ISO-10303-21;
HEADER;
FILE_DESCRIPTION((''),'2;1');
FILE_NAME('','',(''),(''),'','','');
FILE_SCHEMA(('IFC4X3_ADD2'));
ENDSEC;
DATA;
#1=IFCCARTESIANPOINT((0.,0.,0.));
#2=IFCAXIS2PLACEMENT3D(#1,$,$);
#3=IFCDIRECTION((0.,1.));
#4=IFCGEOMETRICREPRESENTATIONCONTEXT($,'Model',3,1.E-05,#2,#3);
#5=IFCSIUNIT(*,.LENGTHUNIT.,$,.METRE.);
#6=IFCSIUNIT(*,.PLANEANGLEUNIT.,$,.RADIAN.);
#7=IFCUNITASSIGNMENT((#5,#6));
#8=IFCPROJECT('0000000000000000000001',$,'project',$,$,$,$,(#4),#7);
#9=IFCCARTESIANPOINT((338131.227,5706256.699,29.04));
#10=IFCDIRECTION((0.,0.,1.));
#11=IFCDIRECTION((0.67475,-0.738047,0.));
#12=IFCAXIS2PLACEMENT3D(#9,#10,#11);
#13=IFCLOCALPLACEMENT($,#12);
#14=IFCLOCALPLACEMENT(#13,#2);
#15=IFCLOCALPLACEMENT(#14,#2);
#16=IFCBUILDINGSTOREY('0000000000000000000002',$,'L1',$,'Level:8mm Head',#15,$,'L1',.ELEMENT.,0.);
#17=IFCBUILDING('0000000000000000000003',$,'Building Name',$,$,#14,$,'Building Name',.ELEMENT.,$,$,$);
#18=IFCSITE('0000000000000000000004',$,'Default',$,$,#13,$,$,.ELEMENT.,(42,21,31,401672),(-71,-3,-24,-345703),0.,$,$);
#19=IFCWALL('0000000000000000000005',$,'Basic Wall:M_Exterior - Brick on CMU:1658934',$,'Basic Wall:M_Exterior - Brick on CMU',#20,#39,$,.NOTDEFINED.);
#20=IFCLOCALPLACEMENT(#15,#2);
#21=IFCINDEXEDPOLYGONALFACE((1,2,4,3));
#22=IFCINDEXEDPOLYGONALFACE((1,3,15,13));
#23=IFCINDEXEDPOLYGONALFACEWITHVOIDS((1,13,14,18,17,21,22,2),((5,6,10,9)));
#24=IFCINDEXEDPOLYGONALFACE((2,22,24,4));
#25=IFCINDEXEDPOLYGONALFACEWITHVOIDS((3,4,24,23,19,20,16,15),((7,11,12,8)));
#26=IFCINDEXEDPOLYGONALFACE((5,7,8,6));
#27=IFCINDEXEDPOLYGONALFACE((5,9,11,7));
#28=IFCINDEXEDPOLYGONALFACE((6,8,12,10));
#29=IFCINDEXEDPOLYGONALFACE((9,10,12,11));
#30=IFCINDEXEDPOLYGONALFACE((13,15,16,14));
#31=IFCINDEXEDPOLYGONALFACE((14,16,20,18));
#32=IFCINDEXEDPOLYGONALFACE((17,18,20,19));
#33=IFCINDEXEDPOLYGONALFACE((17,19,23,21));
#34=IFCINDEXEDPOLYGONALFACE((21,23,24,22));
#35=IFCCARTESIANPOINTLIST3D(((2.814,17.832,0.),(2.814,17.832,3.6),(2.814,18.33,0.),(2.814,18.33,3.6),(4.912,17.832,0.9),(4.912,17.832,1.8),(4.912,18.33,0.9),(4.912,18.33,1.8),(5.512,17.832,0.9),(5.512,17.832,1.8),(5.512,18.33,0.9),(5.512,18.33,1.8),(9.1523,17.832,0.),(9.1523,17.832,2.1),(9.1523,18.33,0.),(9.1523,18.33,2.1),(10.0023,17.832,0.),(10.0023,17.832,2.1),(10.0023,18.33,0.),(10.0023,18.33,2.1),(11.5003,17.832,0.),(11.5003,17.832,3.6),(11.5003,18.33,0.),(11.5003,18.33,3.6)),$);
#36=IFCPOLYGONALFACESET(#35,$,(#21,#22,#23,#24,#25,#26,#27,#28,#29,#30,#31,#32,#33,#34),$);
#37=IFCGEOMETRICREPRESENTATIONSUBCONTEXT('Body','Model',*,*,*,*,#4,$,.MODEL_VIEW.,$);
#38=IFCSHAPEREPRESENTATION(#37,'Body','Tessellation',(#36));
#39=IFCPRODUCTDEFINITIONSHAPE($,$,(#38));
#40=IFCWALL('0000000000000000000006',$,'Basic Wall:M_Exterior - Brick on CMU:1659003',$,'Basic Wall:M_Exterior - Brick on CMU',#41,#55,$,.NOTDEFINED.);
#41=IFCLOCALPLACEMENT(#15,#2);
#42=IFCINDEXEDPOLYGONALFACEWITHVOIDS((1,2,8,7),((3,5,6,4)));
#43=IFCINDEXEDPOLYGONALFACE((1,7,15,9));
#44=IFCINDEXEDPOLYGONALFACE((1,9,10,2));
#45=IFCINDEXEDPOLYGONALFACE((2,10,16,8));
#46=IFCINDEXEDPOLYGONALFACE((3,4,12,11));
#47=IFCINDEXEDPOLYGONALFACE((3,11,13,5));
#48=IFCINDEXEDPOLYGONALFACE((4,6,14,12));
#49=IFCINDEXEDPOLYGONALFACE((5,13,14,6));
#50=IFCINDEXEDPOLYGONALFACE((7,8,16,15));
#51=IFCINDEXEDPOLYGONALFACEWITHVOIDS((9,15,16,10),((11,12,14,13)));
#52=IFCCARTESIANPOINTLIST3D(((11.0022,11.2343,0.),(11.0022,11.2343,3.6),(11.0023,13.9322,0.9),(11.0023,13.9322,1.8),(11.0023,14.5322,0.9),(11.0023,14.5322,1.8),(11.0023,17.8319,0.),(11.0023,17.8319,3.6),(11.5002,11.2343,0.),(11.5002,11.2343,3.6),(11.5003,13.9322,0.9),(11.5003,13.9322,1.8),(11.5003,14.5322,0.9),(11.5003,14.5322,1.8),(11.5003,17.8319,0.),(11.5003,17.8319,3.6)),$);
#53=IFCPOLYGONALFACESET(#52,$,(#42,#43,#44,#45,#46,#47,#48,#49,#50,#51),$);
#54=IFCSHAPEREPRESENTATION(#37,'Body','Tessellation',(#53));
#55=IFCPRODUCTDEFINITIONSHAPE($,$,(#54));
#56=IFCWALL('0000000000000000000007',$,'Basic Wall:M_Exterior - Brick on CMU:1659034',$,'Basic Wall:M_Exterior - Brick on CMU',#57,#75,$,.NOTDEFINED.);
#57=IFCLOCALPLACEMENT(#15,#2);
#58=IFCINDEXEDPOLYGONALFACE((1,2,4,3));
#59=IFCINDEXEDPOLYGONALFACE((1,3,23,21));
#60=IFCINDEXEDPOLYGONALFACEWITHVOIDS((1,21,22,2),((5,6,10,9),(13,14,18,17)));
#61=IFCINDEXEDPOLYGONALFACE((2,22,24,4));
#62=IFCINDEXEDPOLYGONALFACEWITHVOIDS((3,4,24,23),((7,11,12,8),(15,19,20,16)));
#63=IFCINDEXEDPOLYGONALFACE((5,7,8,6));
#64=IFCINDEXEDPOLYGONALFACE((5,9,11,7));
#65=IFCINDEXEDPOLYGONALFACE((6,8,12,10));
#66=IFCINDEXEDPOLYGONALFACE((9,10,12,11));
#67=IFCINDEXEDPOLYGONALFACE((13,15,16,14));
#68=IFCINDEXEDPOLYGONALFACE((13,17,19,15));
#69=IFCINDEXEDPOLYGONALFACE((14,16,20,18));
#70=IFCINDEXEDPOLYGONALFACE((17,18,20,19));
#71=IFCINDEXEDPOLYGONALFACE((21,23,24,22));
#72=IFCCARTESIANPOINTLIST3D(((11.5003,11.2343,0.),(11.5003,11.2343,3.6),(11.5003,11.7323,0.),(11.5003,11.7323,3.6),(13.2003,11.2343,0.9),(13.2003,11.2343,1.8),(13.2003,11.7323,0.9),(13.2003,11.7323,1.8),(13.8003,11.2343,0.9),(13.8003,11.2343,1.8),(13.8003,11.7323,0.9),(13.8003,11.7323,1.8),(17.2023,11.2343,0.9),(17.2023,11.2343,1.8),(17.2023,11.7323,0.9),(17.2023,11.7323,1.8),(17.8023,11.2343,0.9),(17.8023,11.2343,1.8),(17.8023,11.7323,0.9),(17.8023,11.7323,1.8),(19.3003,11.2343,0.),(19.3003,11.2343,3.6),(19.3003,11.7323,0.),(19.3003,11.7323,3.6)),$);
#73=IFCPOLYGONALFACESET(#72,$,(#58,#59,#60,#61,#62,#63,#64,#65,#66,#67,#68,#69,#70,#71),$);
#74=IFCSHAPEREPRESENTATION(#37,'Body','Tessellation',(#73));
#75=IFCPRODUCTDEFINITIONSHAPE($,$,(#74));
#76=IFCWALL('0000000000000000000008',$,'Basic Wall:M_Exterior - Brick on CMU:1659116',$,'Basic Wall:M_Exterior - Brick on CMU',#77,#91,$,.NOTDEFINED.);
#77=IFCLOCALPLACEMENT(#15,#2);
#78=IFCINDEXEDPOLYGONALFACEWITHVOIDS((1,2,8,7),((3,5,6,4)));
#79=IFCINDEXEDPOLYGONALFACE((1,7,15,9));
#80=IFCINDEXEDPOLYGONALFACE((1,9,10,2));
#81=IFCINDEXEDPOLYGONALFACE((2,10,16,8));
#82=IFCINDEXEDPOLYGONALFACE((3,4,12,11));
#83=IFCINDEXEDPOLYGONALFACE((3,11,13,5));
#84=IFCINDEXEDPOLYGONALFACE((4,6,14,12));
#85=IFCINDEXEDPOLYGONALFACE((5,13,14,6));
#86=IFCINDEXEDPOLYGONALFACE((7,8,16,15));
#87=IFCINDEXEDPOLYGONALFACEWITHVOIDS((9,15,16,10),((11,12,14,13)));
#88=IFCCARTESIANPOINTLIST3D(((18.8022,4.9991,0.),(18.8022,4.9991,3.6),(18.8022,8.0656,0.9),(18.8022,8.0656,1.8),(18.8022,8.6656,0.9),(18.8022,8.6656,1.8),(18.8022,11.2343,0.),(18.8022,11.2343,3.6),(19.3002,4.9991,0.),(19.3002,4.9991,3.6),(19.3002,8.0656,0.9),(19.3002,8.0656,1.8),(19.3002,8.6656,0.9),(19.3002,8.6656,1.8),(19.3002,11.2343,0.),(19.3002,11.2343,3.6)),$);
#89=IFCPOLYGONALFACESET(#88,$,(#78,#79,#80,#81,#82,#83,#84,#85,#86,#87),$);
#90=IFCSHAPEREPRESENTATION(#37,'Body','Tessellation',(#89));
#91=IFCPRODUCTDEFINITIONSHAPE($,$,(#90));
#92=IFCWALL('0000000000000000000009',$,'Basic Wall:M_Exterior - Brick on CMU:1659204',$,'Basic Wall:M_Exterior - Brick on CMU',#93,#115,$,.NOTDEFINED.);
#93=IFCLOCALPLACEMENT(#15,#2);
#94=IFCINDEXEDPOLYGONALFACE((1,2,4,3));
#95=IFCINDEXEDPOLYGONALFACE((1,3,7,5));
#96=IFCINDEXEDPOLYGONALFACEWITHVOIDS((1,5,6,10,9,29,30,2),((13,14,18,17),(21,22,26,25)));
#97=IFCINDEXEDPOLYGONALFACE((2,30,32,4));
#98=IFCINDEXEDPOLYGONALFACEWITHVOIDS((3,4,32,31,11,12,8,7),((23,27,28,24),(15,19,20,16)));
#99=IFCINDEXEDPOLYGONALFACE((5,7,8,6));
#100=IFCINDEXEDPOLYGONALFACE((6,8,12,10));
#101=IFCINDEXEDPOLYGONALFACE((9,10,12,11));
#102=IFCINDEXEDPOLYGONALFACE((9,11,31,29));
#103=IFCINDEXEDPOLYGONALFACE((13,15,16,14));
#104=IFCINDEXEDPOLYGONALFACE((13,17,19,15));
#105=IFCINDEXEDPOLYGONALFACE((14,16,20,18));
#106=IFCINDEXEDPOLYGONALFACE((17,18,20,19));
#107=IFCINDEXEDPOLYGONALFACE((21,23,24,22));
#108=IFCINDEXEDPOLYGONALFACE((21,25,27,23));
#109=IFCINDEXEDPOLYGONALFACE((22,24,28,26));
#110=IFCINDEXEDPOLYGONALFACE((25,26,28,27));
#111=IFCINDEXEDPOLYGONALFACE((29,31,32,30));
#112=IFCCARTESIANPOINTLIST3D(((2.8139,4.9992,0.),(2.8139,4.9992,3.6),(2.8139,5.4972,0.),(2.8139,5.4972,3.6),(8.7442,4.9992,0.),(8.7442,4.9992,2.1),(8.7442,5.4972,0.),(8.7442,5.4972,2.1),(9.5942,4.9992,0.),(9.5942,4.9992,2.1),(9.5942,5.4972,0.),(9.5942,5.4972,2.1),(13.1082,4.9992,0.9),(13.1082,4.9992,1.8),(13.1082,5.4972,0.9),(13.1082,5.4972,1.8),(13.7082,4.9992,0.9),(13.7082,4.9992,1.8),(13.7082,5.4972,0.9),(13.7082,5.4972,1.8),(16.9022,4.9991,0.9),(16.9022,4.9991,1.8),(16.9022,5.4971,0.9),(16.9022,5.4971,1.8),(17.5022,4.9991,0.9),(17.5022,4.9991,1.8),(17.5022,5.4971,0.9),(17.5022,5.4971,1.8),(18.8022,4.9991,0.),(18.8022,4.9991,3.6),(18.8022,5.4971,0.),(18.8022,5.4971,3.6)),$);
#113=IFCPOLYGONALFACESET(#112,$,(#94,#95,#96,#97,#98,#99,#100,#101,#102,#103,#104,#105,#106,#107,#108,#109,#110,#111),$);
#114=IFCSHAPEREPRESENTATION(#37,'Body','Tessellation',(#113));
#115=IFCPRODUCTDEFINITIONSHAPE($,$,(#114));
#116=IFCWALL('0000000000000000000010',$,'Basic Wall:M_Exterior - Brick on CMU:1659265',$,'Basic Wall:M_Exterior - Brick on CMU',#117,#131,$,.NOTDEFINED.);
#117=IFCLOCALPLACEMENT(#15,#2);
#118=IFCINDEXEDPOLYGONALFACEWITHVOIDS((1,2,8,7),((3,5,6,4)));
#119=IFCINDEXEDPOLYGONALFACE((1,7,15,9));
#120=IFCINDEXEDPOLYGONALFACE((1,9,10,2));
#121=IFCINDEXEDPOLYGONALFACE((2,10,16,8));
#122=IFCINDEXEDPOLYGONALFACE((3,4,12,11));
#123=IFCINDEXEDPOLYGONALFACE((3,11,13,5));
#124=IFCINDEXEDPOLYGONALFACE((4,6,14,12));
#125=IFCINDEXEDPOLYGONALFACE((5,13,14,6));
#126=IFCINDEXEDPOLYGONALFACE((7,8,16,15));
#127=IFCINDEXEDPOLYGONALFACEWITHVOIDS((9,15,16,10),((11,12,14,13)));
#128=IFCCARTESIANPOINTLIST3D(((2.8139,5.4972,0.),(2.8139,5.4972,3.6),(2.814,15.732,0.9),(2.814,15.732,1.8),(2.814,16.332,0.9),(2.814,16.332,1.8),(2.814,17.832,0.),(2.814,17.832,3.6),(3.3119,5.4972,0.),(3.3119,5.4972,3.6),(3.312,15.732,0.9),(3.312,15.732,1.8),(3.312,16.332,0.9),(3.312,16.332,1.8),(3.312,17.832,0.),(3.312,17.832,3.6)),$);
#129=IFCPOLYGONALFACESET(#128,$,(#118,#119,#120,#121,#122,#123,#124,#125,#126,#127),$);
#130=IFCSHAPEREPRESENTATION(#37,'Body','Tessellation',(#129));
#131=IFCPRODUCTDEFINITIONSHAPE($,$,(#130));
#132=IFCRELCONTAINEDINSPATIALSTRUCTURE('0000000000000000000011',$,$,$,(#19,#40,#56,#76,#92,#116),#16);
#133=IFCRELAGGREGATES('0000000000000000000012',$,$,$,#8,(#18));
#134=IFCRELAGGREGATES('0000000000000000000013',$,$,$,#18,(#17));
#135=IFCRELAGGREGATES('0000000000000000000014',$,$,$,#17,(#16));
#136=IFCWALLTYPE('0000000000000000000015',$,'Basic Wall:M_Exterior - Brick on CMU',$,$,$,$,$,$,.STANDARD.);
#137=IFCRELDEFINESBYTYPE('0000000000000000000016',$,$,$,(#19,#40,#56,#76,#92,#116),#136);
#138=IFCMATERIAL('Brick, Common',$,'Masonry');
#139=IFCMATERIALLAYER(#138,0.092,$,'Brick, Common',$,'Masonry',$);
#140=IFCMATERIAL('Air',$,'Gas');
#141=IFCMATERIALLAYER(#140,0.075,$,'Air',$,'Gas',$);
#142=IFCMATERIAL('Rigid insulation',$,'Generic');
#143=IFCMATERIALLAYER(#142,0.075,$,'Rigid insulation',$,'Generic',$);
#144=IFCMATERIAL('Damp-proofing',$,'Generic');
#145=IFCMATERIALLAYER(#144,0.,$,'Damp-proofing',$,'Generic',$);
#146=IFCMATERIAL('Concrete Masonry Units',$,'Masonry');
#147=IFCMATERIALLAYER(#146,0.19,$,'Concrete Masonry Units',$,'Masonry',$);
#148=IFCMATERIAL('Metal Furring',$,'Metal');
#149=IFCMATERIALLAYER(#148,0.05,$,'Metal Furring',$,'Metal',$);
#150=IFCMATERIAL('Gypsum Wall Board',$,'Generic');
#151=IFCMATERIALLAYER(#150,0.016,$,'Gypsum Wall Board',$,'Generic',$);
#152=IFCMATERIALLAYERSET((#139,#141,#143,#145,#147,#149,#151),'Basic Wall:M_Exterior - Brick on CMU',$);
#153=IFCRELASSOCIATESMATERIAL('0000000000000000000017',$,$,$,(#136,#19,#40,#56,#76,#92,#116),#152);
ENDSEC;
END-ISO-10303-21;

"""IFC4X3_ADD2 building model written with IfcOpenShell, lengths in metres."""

from ifc_helpers import new_model, si_unit, direction, frame, frame_2d, origin, place, context, subcontext, project, spatial, rectangle, extrude, material, layer, layer_set, type_object, element, save


model = new_model("IFC4X3_ADD2")

# Units and contexts
model_context = context("Model", 3, precision=1e-05, world=origin(), true_north=direction((0.0, 1.0)))
body_context = subcontext(model_context, "Body", "Model", "MODEL_VIEW")
ifc_project = project(units=[si_unit("LENGTHUNIT", "METRE"), si_unit("PLANEANGLEUNIT", "RADIAN")], contexts=[model_context])

# Site, building, storey
site_placement = place(None, frame((338131.227, 5706256.699, 29.04), z_axis=(0.0, 0.0, 1.0), x_axis=(0.67475, -0.738047, 0.0)))
site = spatial("IfcSite", under=ifc_project, at=site_placement, Name="Default", CompositionType="ELEMENT", RefLatitude=(42, 21, 31, 401672), RefLongitude=(-71, -3, -24, -345703), RefElevation=0.0)
building_placement = place(site_placement, origin())
building = spatial("IfcBuilding", under=site, at=building_placement, Name="Building Name", LongName="Building Name", CompositionType="ELEMENT")
storey_placement = place(building_placement, origin())
storey = spatial("IfcBuildingStorey", under=building, at=storey_placement, Name="L1", ObjectType="Level:8mm Head", LongName="L1", CompositionType="ELEMENT", Elevation=0.0)

# Wall, openings
ifc_material_1 = material(Name="Brick, Common", Category="Masonry")
ifc_layer_1 = layer(ifc_material_1, 0.092, Name="Brick, Common", Category="Masonry")
ifc_material_2 = material(Name="Air", Category="Gas")
ifc_layer_2 = layer(ifc_material_2, 0.075, Name="Air", Category="Gas")
ifc_material_3 = material(Name="Rigid insulation", Category="Generic")
ifc_layer_3 = layer(ifc_material_3, 0.075, Name="Rigid insulation", Category="Generic")
ifc_material_4 = material(Name="Damp-proofing", Category="Generic")
ifc_layer_4 = layer(ifc_material_4, 0.0, Name="Damp-proofing", Category="Generic")
ifc_material_5 = material(Name="Concrete Masonry Units", Category="Masonry")
ifc_layer_5 = layer(ifc_material_5, 0.19, Name="Concrete Masonry Units", Category="Masonry")
ifc_material_6 = material(Name="Metal Furring", Category="Metal")
ifc_layer_6 = layer(ifc_material_6, 0.05, Name="Metal Furring", Category="Metal")
ifc_material_7 = material(Name="Gypsum Wall Board", Category="Generic")
ifc_layer_7 = layer(ifc_material_7, 0.016, Name="Gypsum Wall Board", Category="Generic")
ifc_layer_set_1 = layer_set([ifc_layer_1, ifc_layer_2, ifc_layer_3, ifc_layer_4, ifc_layer_5, ifc_layer_6, ifc_layer_7], Name="Basic Wall:M_Exterior - Brick on CMU")
wall_type = type_object("IfcWallType", Name="Basic Wall:M_Exterior - Brick on CMU", PredefinedType="STANDARD", material=ifc_layer_set_1)
wall_1_placement = place(storey_placement, frame((2.814, 18.081, 0.0)))
wall_1 = element("IfcWall", 1, at=wall_1_placement, inside=storey, type_object=wall_type, material=ifc_layer_set_1, Name="Basic Wall:M_Exterior - Brick on CMU:1658934", ObjectType="Basic Wall:M_Exterior - Brick on CMU", PredefinedType="NOTDEFINED", context=body_context, shape_type="SweptSolid", body=[
    extrude(rectangle(XDim=8.6863, YDim=0.498, at=frame_2d((4.3431, 0.0), x_axis=(1.0, 0.0))), origin(), (0.0, 0.0, 1.0), 3.6),
])
opening_1_placement = place(wall_1_placement, frame((-2.8139, -18.081, 0.0)))
element("IfcOpeningElement", 2, at=opening_1_placement, cuts=wall_1, PredefinedType="OPENING", context=body_context, shape_type="SweptSolid", body=[
    extrude(rectangle(XDim=2.1, YDim=0.85, at=frame_2d((0.0, 0.0), x_axis=(1.0, 0.0))), frame((9.5772, 16.806, 1.05), z_axis=(0.0, 1.0, 0.0), x_axis=(0.0, 0.0, 1.0)), (0.0, 0.0, 1.0), 3.048),
])
opening_2_placement = place(wall_1_placement, frame((-2.8139, -18.081, 0.9)))
element("IfcOpeningElement", 3, at=opening_2_placement, cuts=wall_1, PredefinedType="OPENING", context=body_context, shape_type="SweptSolid", body=[
    extrude(rectangle(XDim=0.9, YDim=0.6, at=frame_2d((0.0, 0.0), x_axis=(1.0, 0.0))), frame((5.2119, 16.308, 0.45), z_axis=(0.0, 1.0, 0.0), x_axis=(0.0, 0.0, -1.0)), (0.0, 0.0, 1.0), 3.048),
])

# Wall, opening
wall_2_placement = place(storey_placement, frame((11.2513, 17.8319, 0.0), z_axis=(0.0, 0.0, 1.0), x_axis=(-0.000006, -1.0, 0.0)))
wall_2 = element("IfcWall", 4, at=wall_2_placement, inside=storey, type_object=wall_type, material=ifc_layer_set_1, Name="Basic Wall:M_Exterior - Brick on CMU:1659003", ObjectType="Basic Wall:M_Exterior - Brick on CMU", PredefinedType="NOTDEFINED", context=body_context, shape_type="SweptSolid", body=[
    extrude(rectangle(XDim=6.5976, YDim=0.498, at=frame_2d((3.2988, 0.0), x_axis=(-1.0, 0.0))), origin(), (0.0, 0.0, 1.0), 3.6),
])
opening_3_placement = place(wall_2_placement, frame((17.8321, -11.2511, 0.9)))
element("IfcOpeningElement", 5, at=opening_3_placement, cuts=wall_2, PredefinedType="OPENING", context=body_context, shape_type="SweptSolid", body=[
    extrude(rectangle(XDim=0.9, YDim=0.6, at=frame_2d((0.0, 0.0), x_axis=(1.0, 0.0))), frame((-14.2324, 9.4782, 0.45), z_axis=(0.0, 1.0, 0.0), x_axis=(0.0, 0.0, -1.0)), (0.0, 0.0, 1.0), 3.048),
])

# Wall, openings
wall_3_placement = place(storey_placement, frame((11.5003, 11.4833, 0.0)))
wall_3 = element("IfcWall", 6, at=wall_3_placement, inside=storey, type_object=wall_type, material=ifc_layer_set_1, Name="Basic Wall:M_Exterior - Brick on CMU:1659034", ObjectType="Basic Wall:M_Exterior - Brick on CMU", PredefinedType="NOTDEFINED", context=body_context, shape_type="SweptSolid", body=[
    extrude(rectangle(XDim=7.8, YDim=0.498, at=frame_2d((3.9, 0.0), x_axis=(-1.0, 0.0))), origin(), (0.0, 0.0, 1.0), 3.6),
])
opening_4_placement = place(wall_3_placement, frame((-11.5002, -11.4834, 0.9)))
element("IfcOpeningElement", 7, at=opening_4_placement, cuts=wall_3, PredefinedType="OPENING", context=body_context, shape_type="SweptSolid", body=[
    extrude(rectangle(XDim=0.9, YDim=0.6, at=frame_2d((0.0, 0.0), x_axis=(1.0, 0.0))), frame((13.5002, 9.7104, 0.45), z_axis=(0.0, 1.0, 0.0), x_axis=(0.0, 0.0, -1.0)), (0.0, 0.0, 1.0), 3.048),
])
opening_5_placement = place(wall_3_placement, frame((-11.5002, -11.4834, 0.9)))
element("IfcOpeningElement", 8, at=opening_5_placement, cuts=wall_3, PredefinedType="OPENING", context=body_context, shape_type="SweptSolid", body=[
    extrude(rectangle(XDim=0.9, YDim=0.6, at=frame_2d((0.0, 0.0), x_axis=(1.0, 0.0))), frame((17.5022, 9.7104, 0.45), z_axis=(0.0, 1.0, 0.0), x_axis=(0.0, 0.0, -1.0)), (0.0, 0.0, 1.0), 3.048),
])

# Wall, opening
wall_4_placement = place(storey_placement, frame((19.0512, 11.2343, 0.0), z_axis=(0.0, 0.0, 1.0), x_axis=(-0.000006, -1.0, 0.0)))
wall_4 = element("IfcWall", 9, at=wall_4_placement, inside=storey, type_object=wall_type, material=ifc_layer_set_1, Name="Basic Wall:M_Exterior - Brick on CMU:1659116", ObjectType="Basic Wall:M_Exterior - Brick on CMU", PredefinedType="NOTDEFINED", context=body_context, shape_type="SweptSolid", body=[
    extrude(rectangle(XDim=6.2351, YDim=0.498, at=frame_2d((3.1176, 0.0), x_axis=(-1.0, 0.0))), origin(), (0.0, 0.0, 1.0), 3.6),
])
opening_6_placement = place(wall_4_placement, frame((11.2345, -19.0511, 0.9)))
element("IfcOpeningElement", 10, at=opening_6_placement, cuts=wall_4, PredefinedType="OPENING", context=body_context, shape_type="SweptSolid", body=[
    extrude(rectangle(XDim=0.9, YDim=0.6, at=frame_2d((0.0, 0.0), x_axis=(1.0, 0.0))), frame((-8.3658, 17.2782, 0.45), z_axis=(0.0, 1.0, 0.0), x_axis=(0.0, 0.0, -1.0)), (0.0, 0.0, 1.0), 3.048),
])

# Wall, openings
wall_5_placement = place(storey_placement, frame((18.8022, 5.2481, 0.0), z_axis=(0.0, 0.0, 1.0), x_axis=(-1.0, 0.000006, 0.0)))
wall_5 = element("IfcWall", 11, at=wall_5_placement, inside=storey, type_object=wall_type, material=ifc_layer_set_1, Name="Basic Wall:M_Exterior - Brick on CMU:1659204", ObjectType="Basic Wall:M_Exterior - Brick on CMU", PredefinedType="NOTDEFINED", context=body_context, shape_type="SweptSolid", body=[
    extrude(rectangle(XDim=15.9883, YDim=0.498, at=frame_2d((7.9941, 0.0), x_axis=(-1.0, 0.0))), origin(), (0.0, 0.0, 1.0), 3.6),
])
opening_7_placement = place(wall_5_placement, frame((18.8021, 5.2484, 0.0)))
element("IfcOpeningElement", 12, at=opening_7_placement, cuts=wall_5, PredefinedType="OPENING", context=body_context, shape_type="SweptSolid", body=[
    extrude(rectangle(XDim=2.1, YDim=0.85, at=frame_2d((0.0, 0.0), x_axis=(1.0, 0.0))), frame((-9.1692, -6.5232, 1.05), z_axis=(0.0, 1.0, 0.0), x_axis=(0.0, 0.0, 1.0)), (0.0, 0.0, 1.0), 3.048),
])
opening_8_placement = place(wall_5_placement, frame((18.8021, 5.2484, 0.9)))
element("IfcOpeningElement", 13, at=opening_8_placement, cuts=wall_5, PredefinedType="OPENING", context=body_context, shape_type="SweptSolid", body=[
    extrude(rectangle(XDim=0.9, YDim=0.6, at=frame_2d((0.0, 0.0), x_axis=(1.0, 0.0))), frame((-17.2022, -7.0212, 0.45), z_axis=(0.0, 1.0, 0.0), x_axis=(0.0, 0.0, -1.0)), (0.0, 0.0, 1.0), 3.048),
])
opening_9_placement = place(wall_5_placement, frame((18.8021, 5.2484, 0.9)))
element("IfcOpeningElement", 14, at=opening_9_placement, cuts=wall_5, PredefinedType="OPENING", context=body_context, shape_type="SweptSolid", body=[
    extrude(rectangle(XDim=0.9, YDim=0.6, at=frame_2d((0.0, 0.0), x_axis=(1.0, 0.0))), frame((-13.4082, -7.0212, 0.45), z_axis=(0.0, 1.0, 0.0), x_axis=(0.0, 0.0, -1.0)), (0.0, 0.0, 1.0), 3.048),
])

# Wall, opening
wall_6_placement = place(storey_placement, frame((3.0629, 5.4972, 0.0), z_axis=(0.0, 0.0, 1.0), x_axis=(0.000006, 1.0, 0.0)))
wall_6 = element("IfcWall", 15, at=wall_6_placement, inside=storey, type_object=wall_type, material=ifc_layer_set_1, Name="Basic Wall:M_Exterior - Brick on CMU:1659265", ObjectType="Basic Wall:M_Exterior - Brick on CMU", PredefinedType="NOTDEFINED", context=body_context, shape_type="SweptSolid", body=[
    extrude(rectangle(XDim=12.3348, YDim=0.498, at=frame_2d((6.1674, 0.0), x_axis=(-1.0, 0.0))), origin(), (0.0, 0.0, 1.0), 3.6),
])
opening_10_placement = place(wall_6_placement, frame((-5.4973, 3.0628, 0.9)))
element("IfcOpeningElement", 16, at=opening_10_placement, cuts=wall_6, PredefinedType="OPENING", context=body_context, shape_type="SweptSolid", body=[
    extrude(rectangle(XDim=0.9, YDim=0.6, at=frame_2d((0.0, 0.0), x_axis=(1.0, 0.0))), frame((16.032, -4.8359, 0.45), z_axis=(0.0, 1.0, 0.0), x_axis=(0.0, 0.0, -1.0)), (0.0, 0.0, 1.0), 3.048),
])

save(model, "model.ifc")
